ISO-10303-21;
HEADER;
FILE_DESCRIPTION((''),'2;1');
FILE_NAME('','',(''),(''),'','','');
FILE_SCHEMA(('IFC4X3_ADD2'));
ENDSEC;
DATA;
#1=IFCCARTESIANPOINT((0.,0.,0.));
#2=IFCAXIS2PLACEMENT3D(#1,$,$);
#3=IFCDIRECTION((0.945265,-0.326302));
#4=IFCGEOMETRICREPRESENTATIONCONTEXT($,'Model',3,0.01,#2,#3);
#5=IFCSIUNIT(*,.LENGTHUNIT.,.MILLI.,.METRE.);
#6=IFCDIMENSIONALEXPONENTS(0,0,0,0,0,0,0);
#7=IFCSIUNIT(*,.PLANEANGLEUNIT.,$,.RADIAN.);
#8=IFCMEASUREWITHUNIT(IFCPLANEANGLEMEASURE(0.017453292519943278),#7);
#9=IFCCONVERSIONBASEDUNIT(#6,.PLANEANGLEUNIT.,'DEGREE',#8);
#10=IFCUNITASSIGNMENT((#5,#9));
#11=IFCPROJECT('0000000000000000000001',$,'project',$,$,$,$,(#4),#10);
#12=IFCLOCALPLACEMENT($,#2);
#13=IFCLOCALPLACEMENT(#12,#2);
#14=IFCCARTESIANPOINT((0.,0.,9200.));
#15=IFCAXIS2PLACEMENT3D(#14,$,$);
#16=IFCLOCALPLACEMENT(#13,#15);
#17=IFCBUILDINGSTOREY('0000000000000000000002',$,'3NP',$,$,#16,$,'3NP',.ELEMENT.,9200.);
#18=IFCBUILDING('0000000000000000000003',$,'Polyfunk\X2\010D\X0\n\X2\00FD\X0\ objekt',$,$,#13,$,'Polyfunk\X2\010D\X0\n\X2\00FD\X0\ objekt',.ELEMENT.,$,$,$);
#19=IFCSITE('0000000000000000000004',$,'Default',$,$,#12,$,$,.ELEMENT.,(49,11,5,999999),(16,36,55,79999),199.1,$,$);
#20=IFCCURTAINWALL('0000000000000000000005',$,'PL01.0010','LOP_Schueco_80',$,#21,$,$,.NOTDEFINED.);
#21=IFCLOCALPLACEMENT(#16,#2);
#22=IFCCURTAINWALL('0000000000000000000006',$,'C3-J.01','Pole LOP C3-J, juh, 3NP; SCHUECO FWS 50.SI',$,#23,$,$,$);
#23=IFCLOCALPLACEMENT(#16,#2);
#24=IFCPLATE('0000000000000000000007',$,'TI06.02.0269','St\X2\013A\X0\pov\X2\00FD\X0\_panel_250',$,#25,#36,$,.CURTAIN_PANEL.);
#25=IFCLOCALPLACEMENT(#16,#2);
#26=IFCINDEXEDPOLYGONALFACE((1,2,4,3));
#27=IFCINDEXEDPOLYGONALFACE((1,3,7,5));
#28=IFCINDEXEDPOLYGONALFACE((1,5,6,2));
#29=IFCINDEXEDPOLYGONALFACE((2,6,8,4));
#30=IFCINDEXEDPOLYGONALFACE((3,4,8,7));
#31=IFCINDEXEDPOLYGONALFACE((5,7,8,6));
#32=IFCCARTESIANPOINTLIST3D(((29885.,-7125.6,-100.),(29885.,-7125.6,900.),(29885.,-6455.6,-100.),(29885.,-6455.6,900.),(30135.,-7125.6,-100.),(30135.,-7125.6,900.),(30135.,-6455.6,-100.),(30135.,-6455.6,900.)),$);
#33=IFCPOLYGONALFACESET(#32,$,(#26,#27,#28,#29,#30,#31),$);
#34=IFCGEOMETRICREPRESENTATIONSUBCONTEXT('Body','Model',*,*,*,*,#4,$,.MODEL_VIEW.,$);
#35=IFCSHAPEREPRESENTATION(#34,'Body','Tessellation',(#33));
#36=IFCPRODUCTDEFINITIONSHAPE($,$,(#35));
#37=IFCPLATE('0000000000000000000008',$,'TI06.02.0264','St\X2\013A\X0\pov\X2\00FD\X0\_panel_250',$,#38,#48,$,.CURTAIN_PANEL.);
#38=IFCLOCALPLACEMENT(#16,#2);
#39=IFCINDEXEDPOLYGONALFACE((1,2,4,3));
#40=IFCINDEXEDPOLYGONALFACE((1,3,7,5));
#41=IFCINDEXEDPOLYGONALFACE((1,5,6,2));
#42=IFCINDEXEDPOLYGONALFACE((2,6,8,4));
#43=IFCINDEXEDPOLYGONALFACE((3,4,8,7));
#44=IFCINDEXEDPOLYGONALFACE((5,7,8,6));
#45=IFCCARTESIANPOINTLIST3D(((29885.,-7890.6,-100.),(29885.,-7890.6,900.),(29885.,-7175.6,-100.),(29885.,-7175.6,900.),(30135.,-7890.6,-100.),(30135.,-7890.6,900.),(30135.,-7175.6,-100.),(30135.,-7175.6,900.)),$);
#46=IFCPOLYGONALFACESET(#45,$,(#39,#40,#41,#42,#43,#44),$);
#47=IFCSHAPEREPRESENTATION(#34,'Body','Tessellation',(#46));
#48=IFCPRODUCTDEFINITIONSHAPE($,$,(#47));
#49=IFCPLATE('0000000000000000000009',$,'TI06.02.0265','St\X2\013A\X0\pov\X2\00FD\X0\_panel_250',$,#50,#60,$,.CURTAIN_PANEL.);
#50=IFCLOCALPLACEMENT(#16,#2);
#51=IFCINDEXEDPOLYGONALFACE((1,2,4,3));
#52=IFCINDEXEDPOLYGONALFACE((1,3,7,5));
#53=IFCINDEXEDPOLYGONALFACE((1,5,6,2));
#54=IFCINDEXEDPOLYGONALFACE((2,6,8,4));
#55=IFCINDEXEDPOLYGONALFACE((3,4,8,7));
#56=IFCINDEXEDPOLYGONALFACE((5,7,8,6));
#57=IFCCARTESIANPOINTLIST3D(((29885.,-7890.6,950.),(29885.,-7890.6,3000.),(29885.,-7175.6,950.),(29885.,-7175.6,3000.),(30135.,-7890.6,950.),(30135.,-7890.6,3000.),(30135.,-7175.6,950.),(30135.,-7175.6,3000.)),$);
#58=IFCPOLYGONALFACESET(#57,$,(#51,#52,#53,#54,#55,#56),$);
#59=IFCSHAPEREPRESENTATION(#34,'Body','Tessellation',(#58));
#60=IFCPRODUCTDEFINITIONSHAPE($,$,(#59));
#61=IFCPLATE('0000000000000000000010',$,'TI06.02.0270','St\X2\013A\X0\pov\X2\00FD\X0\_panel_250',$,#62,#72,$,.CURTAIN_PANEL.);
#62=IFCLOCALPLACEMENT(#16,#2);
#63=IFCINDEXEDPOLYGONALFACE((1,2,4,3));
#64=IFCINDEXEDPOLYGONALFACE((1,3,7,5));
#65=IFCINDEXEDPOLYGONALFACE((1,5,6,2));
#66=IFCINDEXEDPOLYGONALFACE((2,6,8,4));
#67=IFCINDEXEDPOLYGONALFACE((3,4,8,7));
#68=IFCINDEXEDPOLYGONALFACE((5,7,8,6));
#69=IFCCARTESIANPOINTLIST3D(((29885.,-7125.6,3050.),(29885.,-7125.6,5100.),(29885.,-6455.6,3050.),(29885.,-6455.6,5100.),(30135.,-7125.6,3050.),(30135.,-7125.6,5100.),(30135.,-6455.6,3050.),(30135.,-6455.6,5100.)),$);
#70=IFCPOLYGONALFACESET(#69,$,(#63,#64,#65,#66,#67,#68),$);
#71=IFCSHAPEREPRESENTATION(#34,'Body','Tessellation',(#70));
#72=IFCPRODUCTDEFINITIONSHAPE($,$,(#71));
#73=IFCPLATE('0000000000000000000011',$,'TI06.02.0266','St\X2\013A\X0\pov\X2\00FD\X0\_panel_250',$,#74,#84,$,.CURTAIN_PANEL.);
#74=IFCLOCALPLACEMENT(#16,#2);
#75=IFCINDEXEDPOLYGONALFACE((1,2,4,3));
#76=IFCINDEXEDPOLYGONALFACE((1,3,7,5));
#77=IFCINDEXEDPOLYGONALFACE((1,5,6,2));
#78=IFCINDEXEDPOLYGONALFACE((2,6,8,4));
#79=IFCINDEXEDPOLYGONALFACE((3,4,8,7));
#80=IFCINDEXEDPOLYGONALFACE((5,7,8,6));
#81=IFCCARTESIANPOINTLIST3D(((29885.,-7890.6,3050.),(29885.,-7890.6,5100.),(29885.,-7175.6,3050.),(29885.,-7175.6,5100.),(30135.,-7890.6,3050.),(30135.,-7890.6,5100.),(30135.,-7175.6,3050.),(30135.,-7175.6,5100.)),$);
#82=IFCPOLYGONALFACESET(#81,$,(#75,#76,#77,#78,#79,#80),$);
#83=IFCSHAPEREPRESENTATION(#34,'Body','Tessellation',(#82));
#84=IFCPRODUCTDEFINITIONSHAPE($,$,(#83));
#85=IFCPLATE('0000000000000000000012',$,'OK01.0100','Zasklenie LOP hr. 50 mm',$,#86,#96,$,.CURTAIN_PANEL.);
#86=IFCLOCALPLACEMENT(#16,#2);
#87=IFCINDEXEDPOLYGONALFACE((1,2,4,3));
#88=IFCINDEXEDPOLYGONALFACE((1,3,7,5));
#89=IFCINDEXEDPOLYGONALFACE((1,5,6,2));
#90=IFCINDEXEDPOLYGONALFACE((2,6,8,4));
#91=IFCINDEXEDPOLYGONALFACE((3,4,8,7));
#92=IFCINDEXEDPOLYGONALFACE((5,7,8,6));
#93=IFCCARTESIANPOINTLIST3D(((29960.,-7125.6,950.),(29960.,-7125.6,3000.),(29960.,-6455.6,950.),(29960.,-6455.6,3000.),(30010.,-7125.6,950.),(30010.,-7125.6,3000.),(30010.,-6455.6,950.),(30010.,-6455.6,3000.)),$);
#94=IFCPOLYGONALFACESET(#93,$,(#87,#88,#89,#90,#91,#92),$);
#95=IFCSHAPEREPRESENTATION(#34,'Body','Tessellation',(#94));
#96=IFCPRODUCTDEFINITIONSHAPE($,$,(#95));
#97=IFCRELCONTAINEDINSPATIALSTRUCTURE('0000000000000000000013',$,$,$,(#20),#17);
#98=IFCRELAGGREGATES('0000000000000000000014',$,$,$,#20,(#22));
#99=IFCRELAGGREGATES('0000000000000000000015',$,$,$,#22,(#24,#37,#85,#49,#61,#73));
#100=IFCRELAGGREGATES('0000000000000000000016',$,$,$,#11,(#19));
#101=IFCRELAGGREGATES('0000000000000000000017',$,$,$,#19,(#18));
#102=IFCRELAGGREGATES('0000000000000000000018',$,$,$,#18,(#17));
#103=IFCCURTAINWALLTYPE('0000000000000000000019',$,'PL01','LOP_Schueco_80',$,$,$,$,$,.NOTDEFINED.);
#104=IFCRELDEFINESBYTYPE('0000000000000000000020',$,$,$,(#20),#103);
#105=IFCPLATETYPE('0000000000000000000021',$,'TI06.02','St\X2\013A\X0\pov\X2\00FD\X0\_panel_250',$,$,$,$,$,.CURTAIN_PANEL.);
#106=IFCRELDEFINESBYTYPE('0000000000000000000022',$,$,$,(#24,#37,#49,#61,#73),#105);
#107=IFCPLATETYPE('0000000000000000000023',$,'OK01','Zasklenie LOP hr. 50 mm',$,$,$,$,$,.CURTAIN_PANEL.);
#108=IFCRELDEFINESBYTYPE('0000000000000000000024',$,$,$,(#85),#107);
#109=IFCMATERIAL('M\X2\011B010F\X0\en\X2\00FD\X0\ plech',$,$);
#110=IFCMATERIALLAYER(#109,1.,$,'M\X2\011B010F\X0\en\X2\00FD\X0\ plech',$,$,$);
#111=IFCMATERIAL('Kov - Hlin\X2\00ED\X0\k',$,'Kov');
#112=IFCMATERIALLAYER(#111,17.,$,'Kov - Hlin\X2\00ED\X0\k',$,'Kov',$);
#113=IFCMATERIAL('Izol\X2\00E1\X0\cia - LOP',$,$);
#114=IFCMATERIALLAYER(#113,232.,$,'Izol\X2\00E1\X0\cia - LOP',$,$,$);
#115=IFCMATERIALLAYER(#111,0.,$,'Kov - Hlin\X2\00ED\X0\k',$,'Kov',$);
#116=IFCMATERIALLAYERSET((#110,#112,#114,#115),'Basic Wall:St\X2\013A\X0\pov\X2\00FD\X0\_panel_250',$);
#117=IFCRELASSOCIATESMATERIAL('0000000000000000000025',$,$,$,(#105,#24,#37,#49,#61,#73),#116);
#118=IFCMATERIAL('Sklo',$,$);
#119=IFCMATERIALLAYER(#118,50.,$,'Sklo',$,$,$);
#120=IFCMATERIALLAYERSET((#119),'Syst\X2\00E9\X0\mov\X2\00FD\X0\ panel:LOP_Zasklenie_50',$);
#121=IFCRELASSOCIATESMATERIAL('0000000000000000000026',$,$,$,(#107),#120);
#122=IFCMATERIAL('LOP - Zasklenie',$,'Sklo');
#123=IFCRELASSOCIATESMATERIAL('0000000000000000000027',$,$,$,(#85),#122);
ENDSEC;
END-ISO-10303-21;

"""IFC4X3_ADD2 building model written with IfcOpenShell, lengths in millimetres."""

from ifc_helpers import new_model, entity, si_unit, converted_unit, direction, frame, frame_2d, origin, origin_2d_with_axis, place, context, subcontext, project, spatial, rectangle, extrude, source, transform, mapped, material, layer, layer_set, layer_usage, type_object, type_shapes, element, aggregate, save


model = new_model("IFC4X3_ADD2")

# Units and contexts
model_context = context("Model", 3, precision=0.01, world=origin(), true_north=direction((0.945265, -0.326302)))
body_context = subcontext(model_context, "Body", "Model", "MODEL_VIEW")
ifc_project = project(units=[si_unit("LENGTHUNIT", "METRE", prefix="MILLI"), converted_unit("PLANEANGLEUNIT", "DEGREE", entity("IfcPlaneAngleMeasure", 0.017453292519943278), si_unit("PLANEANGLEUNIT", "RADIAN"), dimensions=[0, 0, 0, 0, 0, 0, 0])], contexts=[model_context])

# Site, building, storey
site_placement = place(None, origin())
site = spatial("IfcSite", under=ifc_project, at=site_placement, Name="Default", CompositionType="ELEMENT", RefLatitude=(49, 11, 5, 999999), RefLongitude=(16, 36, 55, 79999), RefElevation=199.1)
building_placement = place(site_placement, origin())
building = spatial("IfcBuilding", under=site, at=building_placement, Name="Polyfunkčný objekt", LongName="Polyfunkčný objekt", CompositionType="ELEMENT")
storey_placement = place(building_placement, frame((0.0, 0.0, 9200.0)))
storey = spatial("IfcBuildingStorey", under=building, at=storey_placement, Name="3NP", LongName="3NP", CompositionType="ELEMENT", Elevation=9200.0)

# Curtain walls
curtain_wall_type = type_object("IfcCurtainWallType", Name="PL01", Description="LOP_Schueco_80", PredefinedType="NOTDEFINED")
curtain_wall_1_placement = place(storey_placement, frame((0.0, 0.0, -9200.0)))
curtain_wall_1 = element("IfcCurtainWall", 1, at=curtain_wall_1_placement, inside=storey, type_object=curtain_wall_type, Name="PL01.0010", Description="LOP_Schueco_80", PredefinedType="NOTDEFINED")
curtain_wall_2 = element("IfcCurtainWall", 2, Name="C3-J.01", Description="Pole LOP C3-J, juh, 3NP; SCHUECO FWS 50.SI")
aggregate(curtain_wall_1, [curtain_wall_2])

# Shared definitions
ifc_material_1 = material(Name="Měďený plech")
ifc_layer_1 = layer(ifc_material_1, 1.0, Name="Měďený plech")
ifc_material_2 = material(Name="Kov - Hliník", Category="Kov")
ifc_layer_2 = layer(ifc_material_2, 17.0, Name="Kov - Hliník", Category="Kov")
ifc_material_3 = material(Name="Izolácia - LOP")
ifc_layer_3 = layer(ifc_material_3, 232.0, Name="Izolácia - LOP")
ifc_layer_4 = layer(ifc_material_2, 0.0, Name="Kov - Hliník", Category="Kov")
ifc_layer_set_1 = layer_set([ifc_layer_1, ifc_layer_2, ifc_layer_3, ifc_layer_4], Name="Basic Wall:Stĺpový_panel_250")
plate_type_1 = type_object("IfcPlateType", Name="TI06.02", Description="Stĺpový_panel_250", PredefinedType="CURTAIN_PANEL", material=ifc_layer_set_1)

# Plates
ifc_layer_usage_1 = layer_usage(ifc_layer_set_1, "AXIS2", "POSITIVE", -125.0)
plate_1_placement = place(storey_placement, frame((30010.0, -6455.6, -100.0), z_axis=(0.0, 0.0, 1.0), x_axis=(0.0, -1.0, 0.0)))
plate_1 = element("IfcPlate", 3, at=plate_1_placement, type_object=plate_type_1, material=ifc_layer_usage_1, Name="TI06.02.0269", Description="Stĺpový_panel_250", PredefinedType="CURTAIN_PANEL", context=body_context, shape_type="SweptSolid", body=[
    extrude(rectangle(XDim=250.0, YDim=670.0, at=frame_2d((0.0, 0.0), x_axis=(1.0, 0.0))), frame((335.0, 0.0, 0.0), z_axis=(0.0, 0.0, 1.0), x_axis=(0.0, 1.0, 0.0)), (0.0, 0.0, 1.0), 1000.0),
])
ifc_layer_usage_2 = layer_usage(ifc_layer_set_1, "AXIS2", "POSITIVE", -125.0)
plate_2_placement = place(storey_placement, frame((30010.0, -7175.6, -100.0), z_axis=(0.0, 0.0, 1.0), x_axis=(0.0, -1.0, 0.0)))
plate_2 = element("IfcPlate", 4, at=plate_2_placement, type_object=plate_type_1, material=ifc_layer_usage_2, Name="TI06.02.0264", Description="Stĺpový_panel_250", PredefinedType="CURTAIN_PANEL", context=body_context, shape_type="SweptSolid", body=[
    extrude(rectangle(XDim=250.0, YDim=715.0, at=frame_2d((0.0, 0.0), x_axis=(1.0, 0.0))), frame((357.5, 0.0, 0.0), z_axis=(0.0, 0.0, 1.0), x_axis=(0.0, 1.0, 0.0)), (0.0, 0.0, 1.0), 1000.0),
])
ifc_layer_usage_3 = layer_usage(ifc_layer_set_1, "AXIS2", "POSITIVE", -125.0)
plate_3_placement = place(storey_placement, frame((30010.0, -7175.6, 950.0), z_axis=(0.0, 0.0, 1.0), x_axis=(0.0, -1.0, 0.0)))
plate_3 = element("IfcPlate", 5, at=plate_3_placement, type_object=plate_type_1, material=ifc_layer_usage_3, Name="TI06.02.0265", Description="Stĺpový_panel_250", PredefinedType="CURTAIN_PANEL", context=body_context, shape_type="SweptSolid", body=[
    extrude(rectangle(XDim=250.0, YDim=715.0, at=frame_2d((0.0, 0.0), x_axis=(1.0, 0.0))), frame((357.5, 0.0, 0.0), z_axis=(0.0, 0.0, 1.0), x_axis=(0.0, 1.0, 0.0)), (0.0, 0.0, 1.0), 2050.0),
])
ifc_layer_usage_4 = layer_usage(ifc_layer_set_1, "AXIS2", "POSITIVE", -125.0)
plate_4_placement = place(storey_placement, frame((30010.0, -6455.6, 3050.0), z_axis=(0.0, 0.0, 1.0), x_axis=(0.0, -1.0, 0.0)))
plate_4 = element("IfcPlate", 6, at=plate_4_placement, type_object=plate_type_1, material=ifc_layer_usage_4, Name="TI06.02.0270", Description="Stĺpový_panel_250", PredefinedType="CURTAIN_PANEL", context=body_context, shape_type="SweptSolid", body=[
    extrude(rectangle(XDim=250.0, YDim=670.0, at=frame_2d((0.0, 0.0), x_axis=(1.0, 0.0))), frame((335.0, 0.0, 0.0), z_axis=(0.0, 0.0, 1.0), x_axis=(0.0, 1.0, 0.0)), (0.0, 0.0, 1.0), 2050.0),
])
ifc_layer_usage_5 = layer_usage(ifc_layer_set_1, "AXIS2", "POSITIVE", -125.0)
plate_5_placement = place(storey_placement, frame((30010.0, -7175.6, 3050.0), z_axis=(0.0, 0.0, 1.0), x_axis=(0.0, -1.0, 0.0)))
plate_5 = element("IfcPlate", 7, at=plate_5_placement, type_object=plate_type_1, material=ifc_layer_usage_5, Name="TI06.02.0266", Description="Stĺpový_panel_250", PredefinedType="CURTAIN_PANEL", context=body_context, shape_type="SweptSolid", body=[
    extrude(rectangle(XDim=250.0, YDim=715.0, at=frame_2d((0.0, 0.0), x_axis=(1.0, 0.0))), frame((357.5, 0.0, 0.0), z_axis=(0.0, 0.0, 1.0), x_axis=(0.0, 1.0, 0.0)), (0.0, 0.0, 1.0), 2050.0),
])
ifc_material_4 = material(Name="LOP - Zasklenie", Category="Sklo")
ifc_material_5 = material(Name="Sklo")
ifc_layer_5 = layer(ifc_material_5, 50.0, Name="Sklo")
ifc_layer_set_2 = layer_set([ifc_layer_5], Name="Systémový panel:LOP_Zasklenie_50")
plate_type_2 = type_object("IfcPlateType", Name="OK01", Description="Zasklenie LOP hr. 50 mm", PredefinedType="CURTAIN_PANEL", material=ifc_layer_set_2)
shared_shape_1 = source(origin(), body_context, "Body", "SweptSolid", [
    extrude(rectangle(XDim=50.0, YDim=670.0, at=origin_2d_with_axis()), frame((0.0, -25.0, 0.0), z_axis=(0.0, 0.0, 1.0), x_axis=(0.0, 1.0, 0.0)), (0.0, 0.0, 1.0), 2050.0),
])
type_shapes(plate_type_2, [shared_shape_1])
plate_6_placement = place(curtain_wall_1_placement, frame((30010.0, -6790.6, 10150.0), z_axis=(0.0, 0.0, 1.0), x_axis=(0.0, -1.0, 0.0)))
plate_6 = element("IfcPlate", 8, at=plate_6_placement, type_object=plate_type_2, material=ifc_material_4, Name="OK01.0100", Description="Zasklenie LOP hr. 50 mm", PredefinedType="CURTAIN_PANEL", context=body_context, shape_type="MappedRepresentation", body=[
    mapped(shared_shape_1, transform((0.0, 0.0, 0.0), scale=1.0)),
])
aggregate(curtain_wall_2, [plate_1, plate_2, plate_6, plate_3, plate_4, plate_5])

save(model, "model.ifc")
